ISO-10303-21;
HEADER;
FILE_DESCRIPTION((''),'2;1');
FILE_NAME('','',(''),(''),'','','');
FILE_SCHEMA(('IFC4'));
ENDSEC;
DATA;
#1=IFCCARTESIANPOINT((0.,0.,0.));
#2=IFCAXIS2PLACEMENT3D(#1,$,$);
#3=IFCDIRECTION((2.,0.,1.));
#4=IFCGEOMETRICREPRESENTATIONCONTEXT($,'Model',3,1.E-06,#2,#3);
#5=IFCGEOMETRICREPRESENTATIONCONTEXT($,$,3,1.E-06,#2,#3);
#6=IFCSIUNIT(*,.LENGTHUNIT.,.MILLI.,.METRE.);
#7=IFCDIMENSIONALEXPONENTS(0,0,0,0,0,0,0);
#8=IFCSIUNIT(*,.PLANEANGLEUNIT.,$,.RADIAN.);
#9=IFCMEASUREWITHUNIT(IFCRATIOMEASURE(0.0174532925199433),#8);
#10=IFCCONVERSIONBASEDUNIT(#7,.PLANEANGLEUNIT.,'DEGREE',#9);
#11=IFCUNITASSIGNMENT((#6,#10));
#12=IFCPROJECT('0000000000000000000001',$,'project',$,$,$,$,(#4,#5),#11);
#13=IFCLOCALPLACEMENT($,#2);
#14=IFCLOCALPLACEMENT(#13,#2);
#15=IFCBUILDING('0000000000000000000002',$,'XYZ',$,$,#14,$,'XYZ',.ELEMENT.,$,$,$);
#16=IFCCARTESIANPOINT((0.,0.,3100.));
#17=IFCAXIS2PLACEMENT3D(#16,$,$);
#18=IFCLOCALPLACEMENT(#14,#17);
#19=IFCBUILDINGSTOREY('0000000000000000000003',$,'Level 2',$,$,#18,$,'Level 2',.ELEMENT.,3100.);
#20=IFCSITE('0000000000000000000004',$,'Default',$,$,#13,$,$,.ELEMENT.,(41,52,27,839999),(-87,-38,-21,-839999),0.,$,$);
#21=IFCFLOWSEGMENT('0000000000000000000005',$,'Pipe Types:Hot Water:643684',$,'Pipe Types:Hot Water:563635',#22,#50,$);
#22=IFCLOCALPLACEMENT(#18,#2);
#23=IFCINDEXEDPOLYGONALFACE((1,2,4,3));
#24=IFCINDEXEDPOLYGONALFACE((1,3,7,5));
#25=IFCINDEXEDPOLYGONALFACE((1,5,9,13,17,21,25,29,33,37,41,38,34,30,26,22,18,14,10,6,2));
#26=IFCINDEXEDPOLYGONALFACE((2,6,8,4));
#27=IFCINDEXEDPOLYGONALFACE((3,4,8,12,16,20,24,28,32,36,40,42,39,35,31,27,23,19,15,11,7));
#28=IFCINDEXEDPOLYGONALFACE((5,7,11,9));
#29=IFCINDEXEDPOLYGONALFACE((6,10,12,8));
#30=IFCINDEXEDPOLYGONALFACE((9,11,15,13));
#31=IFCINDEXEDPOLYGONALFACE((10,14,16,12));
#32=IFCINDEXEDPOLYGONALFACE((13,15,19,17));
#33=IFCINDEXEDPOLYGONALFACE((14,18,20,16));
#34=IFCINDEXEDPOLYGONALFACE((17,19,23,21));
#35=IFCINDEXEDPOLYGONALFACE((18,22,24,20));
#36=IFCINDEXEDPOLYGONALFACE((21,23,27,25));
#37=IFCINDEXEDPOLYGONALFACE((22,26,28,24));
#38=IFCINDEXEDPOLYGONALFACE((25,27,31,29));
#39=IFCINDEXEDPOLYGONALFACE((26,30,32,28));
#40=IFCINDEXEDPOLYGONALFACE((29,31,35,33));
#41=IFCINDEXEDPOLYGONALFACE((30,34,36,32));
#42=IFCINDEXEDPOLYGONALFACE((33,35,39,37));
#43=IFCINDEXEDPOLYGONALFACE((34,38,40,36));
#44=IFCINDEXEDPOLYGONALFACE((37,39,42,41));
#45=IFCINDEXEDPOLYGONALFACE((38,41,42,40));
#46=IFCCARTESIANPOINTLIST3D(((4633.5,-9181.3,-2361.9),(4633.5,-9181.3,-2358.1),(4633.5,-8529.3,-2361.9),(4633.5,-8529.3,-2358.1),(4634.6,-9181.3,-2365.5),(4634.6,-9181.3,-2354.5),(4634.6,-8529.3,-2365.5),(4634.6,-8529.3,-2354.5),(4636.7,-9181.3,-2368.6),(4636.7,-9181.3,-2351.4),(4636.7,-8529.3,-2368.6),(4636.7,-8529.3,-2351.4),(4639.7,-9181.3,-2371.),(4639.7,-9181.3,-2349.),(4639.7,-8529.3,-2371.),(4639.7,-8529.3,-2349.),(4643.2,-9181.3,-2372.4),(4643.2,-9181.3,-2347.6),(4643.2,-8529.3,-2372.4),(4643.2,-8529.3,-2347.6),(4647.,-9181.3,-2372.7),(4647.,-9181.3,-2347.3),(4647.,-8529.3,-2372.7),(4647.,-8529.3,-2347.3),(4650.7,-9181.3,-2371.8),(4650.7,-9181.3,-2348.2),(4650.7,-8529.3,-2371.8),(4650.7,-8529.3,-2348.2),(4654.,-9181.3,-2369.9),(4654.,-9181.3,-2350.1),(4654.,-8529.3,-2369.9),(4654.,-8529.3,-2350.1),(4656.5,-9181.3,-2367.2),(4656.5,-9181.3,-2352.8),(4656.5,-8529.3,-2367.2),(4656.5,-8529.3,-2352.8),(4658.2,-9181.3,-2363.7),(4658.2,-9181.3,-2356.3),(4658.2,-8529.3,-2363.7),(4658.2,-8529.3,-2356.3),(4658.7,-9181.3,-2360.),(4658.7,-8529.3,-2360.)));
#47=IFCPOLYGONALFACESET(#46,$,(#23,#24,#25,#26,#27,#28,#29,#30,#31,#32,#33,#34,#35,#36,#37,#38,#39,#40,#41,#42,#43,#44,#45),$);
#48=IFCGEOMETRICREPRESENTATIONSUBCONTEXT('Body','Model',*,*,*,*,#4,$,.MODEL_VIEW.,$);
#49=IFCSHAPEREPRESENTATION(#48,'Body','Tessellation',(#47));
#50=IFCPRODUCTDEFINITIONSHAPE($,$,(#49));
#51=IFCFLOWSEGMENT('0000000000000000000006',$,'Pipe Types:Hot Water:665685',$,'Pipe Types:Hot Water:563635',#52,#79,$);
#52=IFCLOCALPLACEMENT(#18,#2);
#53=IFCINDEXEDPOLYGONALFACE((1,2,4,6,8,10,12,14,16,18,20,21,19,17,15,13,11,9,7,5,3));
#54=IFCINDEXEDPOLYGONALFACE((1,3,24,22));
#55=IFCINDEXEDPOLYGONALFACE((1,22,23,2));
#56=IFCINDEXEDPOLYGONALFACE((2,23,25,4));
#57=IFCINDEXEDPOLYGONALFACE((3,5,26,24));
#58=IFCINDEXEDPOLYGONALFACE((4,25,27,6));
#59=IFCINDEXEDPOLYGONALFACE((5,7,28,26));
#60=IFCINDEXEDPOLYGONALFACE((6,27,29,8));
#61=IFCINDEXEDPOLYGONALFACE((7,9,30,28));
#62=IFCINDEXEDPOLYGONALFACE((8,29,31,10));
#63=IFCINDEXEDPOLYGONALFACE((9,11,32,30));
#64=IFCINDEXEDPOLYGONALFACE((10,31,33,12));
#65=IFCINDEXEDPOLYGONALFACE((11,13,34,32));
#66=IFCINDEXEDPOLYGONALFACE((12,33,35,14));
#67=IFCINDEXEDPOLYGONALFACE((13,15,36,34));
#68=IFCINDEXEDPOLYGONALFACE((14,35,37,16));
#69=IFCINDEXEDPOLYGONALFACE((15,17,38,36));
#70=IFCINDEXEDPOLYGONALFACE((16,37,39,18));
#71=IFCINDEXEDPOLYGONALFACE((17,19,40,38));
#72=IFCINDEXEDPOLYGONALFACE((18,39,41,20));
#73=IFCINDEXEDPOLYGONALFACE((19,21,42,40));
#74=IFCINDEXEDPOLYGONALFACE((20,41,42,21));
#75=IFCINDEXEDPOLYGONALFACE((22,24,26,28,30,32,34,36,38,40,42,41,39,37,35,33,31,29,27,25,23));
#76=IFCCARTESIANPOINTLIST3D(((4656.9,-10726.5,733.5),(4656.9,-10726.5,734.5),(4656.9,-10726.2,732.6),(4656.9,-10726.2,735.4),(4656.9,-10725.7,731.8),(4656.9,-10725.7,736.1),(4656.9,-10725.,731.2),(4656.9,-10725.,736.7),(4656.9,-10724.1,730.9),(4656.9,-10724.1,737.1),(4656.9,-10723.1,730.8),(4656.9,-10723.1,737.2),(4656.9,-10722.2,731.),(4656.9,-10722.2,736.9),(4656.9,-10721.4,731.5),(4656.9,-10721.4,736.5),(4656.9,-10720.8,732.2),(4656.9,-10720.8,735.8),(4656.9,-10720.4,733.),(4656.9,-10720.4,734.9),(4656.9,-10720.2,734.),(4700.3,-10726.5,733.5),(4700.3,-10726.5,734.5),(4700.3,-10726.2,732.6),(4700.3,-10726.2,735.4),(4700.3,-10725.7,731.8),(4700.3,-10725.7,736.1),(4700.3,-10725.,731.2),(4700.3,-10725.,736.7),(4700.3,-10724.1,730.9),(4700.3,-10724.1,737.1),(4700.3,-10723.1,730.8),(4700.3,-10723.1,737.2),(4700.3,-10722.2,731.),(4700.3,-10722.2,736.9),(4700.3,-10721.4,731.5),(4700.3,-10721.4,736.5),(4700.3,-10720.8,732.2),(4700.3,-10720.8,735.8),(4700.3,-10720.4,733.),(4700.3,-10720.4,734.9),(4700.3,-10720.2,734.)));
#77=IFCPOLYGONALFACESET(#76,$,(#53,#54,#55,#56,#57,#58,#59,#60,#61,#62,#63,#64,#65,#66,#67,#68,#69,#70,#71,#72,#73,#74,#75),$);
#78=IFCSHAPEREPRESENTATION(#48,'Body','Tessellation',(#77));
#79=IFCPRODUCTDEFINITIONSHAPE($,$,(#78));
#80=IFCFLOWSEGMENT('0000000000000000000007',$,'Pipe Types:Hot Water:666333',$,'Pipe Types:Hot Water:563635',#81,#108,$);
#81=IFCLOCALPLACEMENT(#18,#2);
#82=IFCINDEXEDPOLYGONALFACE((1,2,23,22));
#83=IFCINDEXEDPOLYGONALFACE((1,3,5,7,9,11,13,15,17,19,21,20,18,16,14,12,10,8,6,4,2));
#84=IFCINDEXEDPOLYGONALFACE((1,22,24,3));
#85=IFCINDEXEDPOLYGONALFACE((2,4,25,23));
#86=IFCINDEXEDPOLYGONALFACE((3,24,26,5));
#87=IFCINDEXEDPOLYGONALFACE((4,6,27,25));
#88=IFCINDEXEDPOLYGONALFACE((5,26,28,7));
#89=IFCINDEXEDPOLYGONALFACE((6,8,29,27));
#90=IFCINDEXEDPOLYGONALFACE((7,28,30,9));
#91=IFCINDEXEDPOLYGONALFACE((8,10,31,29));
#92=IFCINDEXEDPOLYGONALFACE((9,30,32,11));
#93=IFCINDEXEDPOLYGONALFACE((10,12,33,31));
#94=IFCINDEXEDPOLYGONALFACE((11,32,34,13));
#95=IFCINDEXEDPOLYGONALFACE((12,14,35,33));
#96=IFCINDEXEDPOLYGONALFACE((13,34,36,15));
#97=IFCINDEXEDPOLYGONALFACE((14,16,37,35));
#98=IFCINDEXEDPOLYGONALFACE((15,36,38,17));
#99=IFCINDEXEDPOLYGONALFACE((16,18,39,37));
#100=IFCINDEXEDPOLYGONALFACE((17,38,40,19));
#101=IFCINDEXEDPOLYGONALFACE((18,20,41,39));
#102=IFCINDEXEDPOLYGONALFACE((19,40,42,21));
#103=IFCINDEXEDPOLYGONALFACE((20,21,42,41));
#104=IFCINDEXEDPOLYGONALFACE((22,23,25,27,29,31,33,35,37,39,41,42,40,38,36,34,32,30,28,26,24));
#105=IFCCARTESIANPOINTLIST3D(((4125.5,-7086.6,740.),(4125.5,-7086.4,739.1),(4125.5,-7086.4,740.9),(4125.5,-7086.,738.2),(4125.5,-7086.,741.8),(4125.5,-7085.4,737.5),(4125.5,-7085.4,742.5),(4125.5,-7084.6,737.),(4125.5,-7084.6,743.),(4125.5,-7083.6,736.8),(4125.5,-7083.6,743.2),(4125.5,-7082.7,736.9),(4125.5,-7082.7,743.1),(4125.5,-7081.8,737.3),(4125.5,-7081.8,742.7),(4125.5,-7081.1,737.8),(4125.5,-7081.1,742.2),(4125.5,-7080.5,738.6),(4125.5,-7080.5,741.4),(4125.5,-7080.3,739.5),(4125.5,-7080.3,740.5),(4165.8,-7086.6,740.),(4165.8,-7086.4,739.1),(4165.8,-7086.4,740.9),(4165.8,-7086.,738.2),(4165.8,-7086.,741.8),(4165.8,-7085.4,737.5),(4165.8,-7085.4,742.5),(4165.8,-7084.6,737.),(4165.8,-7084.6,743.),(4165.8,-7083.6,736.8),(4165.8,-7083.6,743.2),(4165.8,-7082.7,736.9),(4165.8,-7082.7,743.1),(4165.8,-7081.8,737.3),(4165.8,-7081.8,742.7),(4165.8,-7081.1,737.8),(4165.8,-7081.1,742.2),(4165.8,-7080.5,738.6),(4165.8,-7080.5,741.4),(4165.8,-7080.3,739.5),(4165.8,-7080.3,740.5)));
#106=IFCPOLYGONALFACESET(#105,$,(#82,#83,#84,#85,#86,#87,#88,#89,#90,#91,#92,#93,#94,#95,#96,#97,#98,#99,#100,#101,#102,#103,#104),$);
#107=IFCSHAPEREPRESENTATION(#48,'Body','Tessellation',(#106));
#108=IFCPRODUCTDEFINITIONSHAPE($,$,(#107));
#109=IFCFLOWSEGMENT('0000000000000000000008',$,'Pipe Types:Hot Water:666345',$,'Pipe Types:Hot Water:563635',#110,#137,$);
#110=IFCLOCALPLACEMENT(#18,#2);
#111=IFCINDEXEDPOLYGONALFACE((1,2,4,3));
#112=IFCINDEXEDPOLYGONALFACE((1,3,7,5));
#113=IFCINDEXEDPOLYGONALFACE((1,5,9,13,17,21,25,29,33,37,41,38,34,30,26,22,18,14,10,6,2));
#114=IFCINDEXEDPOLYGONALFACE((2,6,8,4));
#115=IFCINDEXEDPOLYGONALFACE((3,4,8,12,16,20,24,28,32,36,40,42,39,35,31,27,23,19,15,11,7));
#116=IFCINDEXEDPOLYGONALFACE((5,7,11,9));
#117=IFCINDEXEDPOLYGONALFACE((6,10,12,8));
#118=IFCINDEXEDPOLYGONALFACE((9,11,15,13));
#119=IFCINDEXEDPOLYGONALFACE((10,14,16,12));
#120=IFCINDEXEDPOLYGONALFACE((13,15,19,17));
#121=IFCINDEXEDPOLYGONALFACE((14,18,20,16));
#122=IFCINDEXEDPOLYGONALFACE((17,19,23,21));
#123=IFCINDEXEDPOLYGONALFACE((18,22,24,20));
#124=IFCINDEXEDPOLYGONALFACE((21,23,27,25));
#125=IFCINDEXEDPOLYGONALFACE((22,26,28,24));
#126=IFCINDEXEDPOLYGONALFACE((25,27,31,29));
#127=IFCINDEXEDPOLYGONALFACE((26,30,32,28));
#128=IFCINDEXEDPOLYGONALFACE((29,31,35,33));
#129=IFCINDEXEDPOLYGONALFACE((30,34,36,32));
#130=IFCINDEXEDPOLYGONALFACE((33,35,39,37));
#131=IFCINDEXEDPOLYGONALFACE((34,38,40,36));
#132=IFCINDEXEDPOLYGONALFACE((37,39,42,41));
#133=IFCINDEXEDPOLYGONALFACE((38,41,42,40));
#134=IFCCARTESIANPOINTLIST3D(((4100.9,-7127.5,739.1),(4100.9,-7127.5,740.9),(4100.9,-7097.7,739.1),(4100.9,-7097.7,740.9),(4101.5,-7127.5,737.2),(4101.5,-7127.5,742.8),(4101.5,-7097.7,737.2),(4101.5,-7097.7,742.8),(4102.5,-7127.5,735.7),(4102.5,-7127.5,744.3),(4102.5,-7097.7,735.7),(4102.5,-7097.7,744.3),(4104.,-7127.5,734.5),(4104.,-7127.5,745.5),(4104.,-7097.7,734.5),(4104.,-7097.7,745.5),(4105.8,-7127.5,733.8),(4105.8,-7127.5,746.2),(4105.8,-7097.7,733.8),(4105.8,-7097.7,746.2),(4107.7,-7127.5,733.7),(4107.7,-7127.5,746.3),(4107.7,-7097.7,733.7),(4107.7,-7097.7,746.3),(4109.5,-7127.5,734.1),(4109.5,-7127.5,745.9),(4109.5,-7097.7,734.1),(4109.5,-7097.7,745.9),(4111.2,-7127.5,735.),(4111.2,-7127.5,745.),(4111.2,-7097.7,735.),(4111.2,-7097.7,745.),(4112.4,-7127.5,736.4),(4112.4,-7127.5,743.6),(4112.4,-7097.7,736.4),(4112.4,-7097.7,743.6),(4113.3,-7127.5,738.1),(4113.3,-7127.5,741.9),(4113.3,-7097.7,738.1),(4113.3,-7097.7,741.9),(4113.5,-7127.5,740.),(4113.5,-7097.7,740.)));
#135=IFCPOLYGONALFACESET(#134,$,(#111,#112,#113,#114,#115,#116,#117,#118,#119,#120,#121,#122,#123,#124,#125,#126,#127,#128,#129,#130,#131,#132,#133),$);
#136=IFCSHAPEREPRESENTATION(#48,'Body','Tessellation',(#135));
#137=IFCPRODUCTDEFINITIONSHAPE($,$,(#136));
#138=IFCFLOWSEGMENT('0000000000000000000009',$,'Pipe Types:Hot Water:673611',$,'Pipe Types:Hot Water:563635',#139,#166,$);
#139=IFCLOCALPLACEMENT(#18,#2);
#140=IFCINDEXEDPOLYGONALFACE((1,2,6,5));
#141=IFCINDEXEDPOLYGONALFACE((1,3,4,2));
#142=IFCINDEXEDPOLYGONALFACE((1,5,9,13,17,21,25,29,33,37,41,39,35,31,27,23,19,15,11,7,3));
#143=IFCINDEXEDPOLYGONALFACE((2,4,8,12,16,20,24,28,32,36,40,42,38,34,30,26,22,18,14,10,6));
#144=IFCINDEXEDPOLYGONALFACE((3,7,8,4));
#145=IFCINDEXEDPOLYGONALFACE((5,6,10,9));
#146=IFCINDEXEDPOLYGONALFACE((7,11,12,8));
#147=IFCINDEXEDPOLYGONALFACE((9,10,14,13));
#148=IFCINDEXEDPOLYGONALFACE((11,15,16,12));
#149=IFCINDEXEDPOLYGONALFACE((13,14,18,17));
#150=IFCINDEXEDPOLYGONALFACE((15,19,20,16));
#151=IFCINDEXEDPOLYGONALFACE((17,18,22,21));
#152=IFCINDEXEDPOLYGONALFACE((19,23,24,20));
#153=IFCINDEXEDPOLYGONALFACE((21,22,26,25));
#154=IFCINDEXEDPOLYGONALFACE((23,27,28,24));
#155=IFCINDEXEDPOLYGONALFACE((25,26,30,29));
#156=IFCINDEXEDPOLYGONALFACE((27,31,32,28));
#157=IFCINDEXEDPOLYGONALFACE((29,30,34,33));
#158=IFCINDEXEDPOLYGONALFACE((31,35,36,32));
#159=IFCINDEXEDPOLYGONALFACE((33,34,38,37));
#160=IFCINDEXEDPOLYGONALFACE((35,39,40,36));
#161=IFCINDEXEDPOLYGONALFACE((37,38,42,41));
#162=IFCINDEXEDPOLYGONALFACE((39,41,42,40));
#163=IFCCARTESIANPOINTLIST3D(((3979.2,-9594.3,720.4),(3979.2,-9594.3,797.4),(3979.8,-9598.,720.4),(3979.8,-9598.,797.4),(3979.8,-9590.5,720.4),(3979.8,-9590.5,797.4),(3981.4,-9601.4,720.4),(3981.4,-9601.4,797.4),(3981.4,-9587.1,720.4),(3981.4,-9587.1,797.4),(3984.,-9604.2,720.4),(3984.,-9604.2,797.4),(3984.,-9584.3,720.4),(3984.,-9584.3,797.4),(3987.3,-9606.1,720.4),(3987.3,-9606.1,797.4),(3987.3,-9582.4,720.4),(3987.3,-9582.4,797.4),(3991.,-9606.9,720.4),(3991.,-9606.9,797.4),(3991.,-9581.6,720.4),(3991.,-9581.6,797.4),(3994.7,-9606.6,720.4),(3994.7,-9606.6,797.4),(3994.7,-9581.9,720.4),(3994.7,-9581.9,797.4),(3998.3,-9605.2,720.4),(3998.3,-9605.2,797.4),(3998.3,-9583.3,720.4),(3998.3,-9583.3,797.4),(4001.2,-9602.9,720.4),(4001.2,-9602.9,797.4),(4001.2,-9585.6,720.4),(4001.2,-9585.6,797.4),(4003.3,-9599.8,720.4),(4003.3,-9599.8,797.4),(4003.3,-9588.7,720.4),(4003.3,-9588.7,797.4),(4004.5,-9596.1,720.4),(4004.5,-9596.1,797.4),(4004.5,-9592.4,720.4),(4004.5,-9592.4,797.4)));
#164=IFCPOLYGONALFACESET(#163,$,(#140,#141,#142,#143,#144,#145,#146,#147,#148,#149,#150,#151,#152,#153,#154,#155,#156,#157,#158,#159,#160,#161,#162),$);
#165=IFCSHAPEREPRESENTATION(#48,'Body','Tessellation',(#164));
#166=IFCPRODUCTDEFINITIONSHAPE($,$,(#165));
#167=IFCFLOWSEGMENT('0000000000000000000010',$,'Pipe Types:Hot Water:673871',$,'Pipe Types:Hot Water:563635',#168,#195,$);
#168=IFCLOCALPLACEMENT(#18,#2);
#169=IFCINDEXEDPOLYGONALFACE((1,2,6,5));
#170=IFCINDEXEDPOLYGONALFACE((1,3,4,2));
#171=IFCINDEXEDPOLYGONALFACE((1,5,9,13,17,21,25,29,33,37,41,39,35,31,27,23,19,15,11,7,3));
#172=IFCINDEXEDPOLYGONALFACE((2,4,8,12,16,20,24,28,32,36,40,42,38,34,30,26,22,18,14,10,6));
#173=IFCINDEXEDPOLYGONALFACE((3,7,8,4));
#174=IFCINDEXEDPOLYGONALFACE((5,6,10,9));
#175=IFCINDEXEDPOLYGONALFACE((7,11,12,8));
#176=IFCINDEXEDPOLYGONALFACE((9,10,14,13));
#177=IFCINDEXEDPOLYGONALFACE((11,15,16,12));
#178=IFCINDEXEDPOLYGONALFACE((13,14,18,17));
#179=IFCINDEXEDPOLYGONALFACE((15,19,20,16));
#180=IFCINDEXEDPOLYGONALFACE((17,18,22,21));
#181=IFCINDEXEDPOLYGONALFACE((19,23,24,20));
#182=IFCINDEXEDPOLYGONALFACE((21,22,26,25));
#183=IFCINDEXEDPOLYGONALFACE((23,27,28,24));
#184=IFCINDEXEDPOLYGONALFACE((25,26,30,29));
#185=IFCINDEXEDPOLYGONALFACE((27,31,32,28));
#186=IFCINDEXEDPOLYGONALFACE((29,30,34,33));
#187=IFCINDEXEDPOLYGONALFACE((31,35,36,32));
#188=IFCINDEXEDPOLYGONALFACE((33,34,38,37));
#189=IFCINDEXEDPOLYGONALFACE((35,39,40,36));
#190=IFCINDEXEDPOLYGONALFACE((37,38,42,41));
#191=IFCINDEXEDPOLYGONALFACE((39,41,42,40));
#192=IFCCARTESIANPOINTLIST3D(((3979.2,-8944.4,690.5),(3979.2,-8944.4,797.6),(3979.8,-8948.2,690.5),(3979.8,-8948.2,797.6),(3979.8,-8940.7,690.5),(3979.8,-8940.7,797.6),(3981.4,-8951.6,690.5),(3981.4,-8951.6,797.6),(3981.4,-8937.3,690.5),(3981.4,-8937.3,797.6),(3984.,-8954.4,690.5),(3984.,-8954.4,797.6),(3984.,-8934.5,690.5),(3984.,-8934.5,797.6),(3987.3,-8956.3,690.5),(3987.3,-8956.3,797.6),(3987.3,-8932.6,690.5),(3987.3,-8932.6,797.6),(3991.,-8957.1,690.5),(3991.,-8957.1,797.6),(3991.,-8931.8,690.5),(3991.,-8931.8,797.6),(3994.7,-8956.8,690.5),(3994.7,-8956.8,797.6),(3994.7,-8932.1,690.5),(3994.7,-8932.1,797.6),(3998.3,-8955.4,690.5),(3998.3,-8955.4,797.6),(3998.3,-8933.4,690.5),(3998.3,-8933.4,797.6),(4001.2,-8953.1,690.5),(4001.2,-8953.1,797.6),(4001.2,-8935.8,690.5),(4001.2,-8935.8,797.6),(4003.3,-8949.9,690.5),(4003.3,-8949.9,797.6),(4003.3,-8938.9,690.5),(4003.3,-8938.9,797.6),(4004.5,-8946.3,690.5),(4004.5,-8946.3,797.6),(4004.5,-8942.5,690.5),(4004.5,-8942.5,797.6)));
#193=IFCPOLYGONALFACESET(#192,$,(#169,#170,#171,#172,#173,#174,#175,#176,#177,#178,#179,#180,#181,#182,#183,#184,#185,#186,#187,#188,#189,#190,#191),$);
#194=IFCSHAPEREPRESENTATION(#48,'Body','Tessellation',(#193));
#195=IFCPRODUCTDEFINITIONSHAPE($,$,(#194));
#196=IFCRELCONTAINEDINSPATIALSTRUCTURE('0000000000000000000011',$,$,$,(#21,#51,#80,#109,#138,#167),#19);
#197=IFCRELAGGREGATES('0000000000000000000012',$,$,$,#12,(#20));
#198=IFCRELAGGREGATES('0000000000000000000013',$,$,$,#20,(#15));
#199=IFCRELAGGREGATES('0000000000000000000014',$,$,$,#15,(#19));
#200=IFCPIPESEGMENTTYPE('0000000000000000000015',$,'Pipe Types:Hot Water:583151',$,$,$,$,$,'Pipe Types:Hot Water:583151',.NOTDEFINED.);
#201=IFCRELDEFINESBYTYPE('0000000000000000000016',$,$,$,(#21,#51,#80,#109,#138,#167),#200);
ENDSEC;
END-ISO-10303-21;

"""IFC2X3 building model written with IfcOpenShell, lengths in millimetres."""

from ifc_helpers import new_model, entity, si_unit, converted_unit, direction, frame, frame_2d, origin, origin_2d_with_axis, place, context, subcontext, project, spatial, circle, extrude, type_object, element, save


model = new_model("IFC2X3")

# Units and contexts
model_context = context("Model", 3, precision=1e-06, world=origin(), true_north=direction((2.0, 0.0, 1.0)))
context_of_model = context(None, 3, precision=1e-06, world=origin(), true_north=direction((2.0, 0.0, 1.0)))
body_context = subcontext(model_context, "Body", "Model", "MODEL_VIEW")
ifc_project = project(units=[si_unit("LENGTHUNIT", "METRE", prefix="MILLI"), converted_unit("PLANEANGLEUNIT", "DEGREE", entity("IfcRatioMeasure", 0.0174532925199433), si_unit("PLANEANGLEUNIT", "RADIAN"), dimensions=[0, 0, 0, 0, 0, 0, 0])], contexts=[model_context, context_of_model])

# Site, building, storey
site_placement = place(None, origin())
site = spatial("IfcSite", under=ifc_project, at=site_placement, Name="Default", CompositionType="ELEMENT", RefLatitude=(41, 52, 27, 839999), RefLongitude=(-87, -38, -21, -839999), RefElevation=0.0)
building_placement = place(site_placement, origin())
building = spatial("IfcBuilding", under=site, at=building_placement, Name="XYZ", LongName="XYZ", CompositionType="ELEMENT")
storey_placement = place(building_placement, frame((0.0, 0.0, 3100.0)))
storey = spatial("IfcBuildingStorey", under=building, at=storey_placement, Name="Level 2", LongName="Level 2", CompositionType="ELEMENT", Elevation=3100.0)

# Flow segments
pipe_segment_type_1 = type_object("IfcPipeSegmentType", Name="Pipe Types:Hot Water:583151", ElementType="Pipe Types:Hot Water:583151", PredefinedType="NOTDEFINED")
flow_segment_1_placement = place(storey_placement, origin())
element("IfcFlowSegment", 1, at=flow_segment_1_placement, inside=storey, type_object=pipe_segment_type_1, Name="Pipe Types:Hot Water:643684", ObjectType="Pipe Types:Hot Water:563635", context=body_context, shape_type="SweptSolid", body=[
    extrude(circle(Radius=12.7, at=origin_2d_with_axis()), frame((4646.0, -9181.3, -2360.0), z_axis=(0.0, 1.0, 0.0), x_axis=(1.0, 0.0, 0.0)), (0.0, 0.0, 1.0), 652.0),
])
flow_segment_2_placement = place(storey_placement, origin())
element("IfcFlowSegment", 2, at=flow_segment_2_placement, inside=storey, type_object=pipe_segment_type_1, Name="Pipe Types:Hot Water:665685", ObjectType="Pipe Types:Hot Water:563635", context=body_context, shape_type="SweptSolid", body=[
    extrude(circle(Radius=3.2, at=origin_2d_with_axis()), frame((4656.9, -10723.4, 734.0), z_axis=(1.0, 0.0, 0.0), x_axis=(0.0, 1.0, 0.0)), (0.0, 0.0, 1.0), 43.5),
])
flow_segment_3_placement = place(storey_placement, origin())
element("IfcFlowSegment", 3, at=flow_segment_3_placement, inside=storey, type_object=pipe_segment_type_1, Name="Pipe Types:Hot Water:666333", ObjectType="Pipe Types:Hot Water:563635", context=body_context, shape_type="SweptSolid", body=[
    extrude(circle(Radius=3.2, at=frame_2d((0.0, 0.0), x_axis=(1.0, 0.0))), frame((4125.5, -7083.4, 740.0), z_axis=(1.0, 0.0, 0.0), x_axis=(0.0, -1.0, 0.0)), (0.0, 0.0, 1.0), 40.4),
])
flow_segment_4_placement = place(storey_placement, origin())
element("IfcFlowSegment", 4, at=flow_segment_4_placement, inside=storey, type_object=pipe_segment_type_1, Name="Pipe Types:Hot Water:666345", ObjectType="Pipe Types:Hot Water:563635", context=body_context, shape_type="SweptSolid", body=[
    extrude(circle(Radius=6.3, at=frame_2d((0.0, 0.0), x_axis=(1.0, 0.0))), frame((4107.2, -7127.5, 740.0), z_axis=(0.0, 1.0, 0.0), x_axis=(1.0, 0.0, 0.0)), (0.0, 0.0, 1.0), 29.8),
])
flow_segment_5_placement = place(storey_placement, origin())
element("IfcFlowSegment", 5, at=flow_segment_5_placement, inside=storey, type_object=pipe_segment_type_1, Name="Pipe Types:Hot Water:673611", ObjectType="Pipe Types:Hot Water:563635", context=body_context, shape_type="SweptSolid", body=[
    extrude(circle(Radius=12.7, at=origin_2d_with_axis()), frame((3991.9, -9594.3, 720.4), z_axis=(0.0, 0.0, 1.0), x_axis=(-1.0, 0.0, 0.0)), (0.0, 0.0, 1.0), 77.1),
])
flow_segment_6_placement = place(storey_placement, origin())
element("IfcFlowSegment", 6, at=flow_segment_6_placement, inside=storey, type_object=pipe_segment_type_1, Name="Pipe Types:Hot Water:673871", ObjectType="Pipe Types:Hot Water:563635", context=body_context, shape_type="SweptSolid", body=[
    extrude(circle(Radius=12.7, at=frame_2d((0.0, 0.0), x_axis=(1.0, 0.0))), frame((3991.9, -8944.4, 690.5), z_axis=(0.0, 0.0, 1.0), x_axis=(-1.0, 0.0, 0.0)), (0.0, 0.0, 1.0), 107.1),
])

save(model, "model.ifc")
